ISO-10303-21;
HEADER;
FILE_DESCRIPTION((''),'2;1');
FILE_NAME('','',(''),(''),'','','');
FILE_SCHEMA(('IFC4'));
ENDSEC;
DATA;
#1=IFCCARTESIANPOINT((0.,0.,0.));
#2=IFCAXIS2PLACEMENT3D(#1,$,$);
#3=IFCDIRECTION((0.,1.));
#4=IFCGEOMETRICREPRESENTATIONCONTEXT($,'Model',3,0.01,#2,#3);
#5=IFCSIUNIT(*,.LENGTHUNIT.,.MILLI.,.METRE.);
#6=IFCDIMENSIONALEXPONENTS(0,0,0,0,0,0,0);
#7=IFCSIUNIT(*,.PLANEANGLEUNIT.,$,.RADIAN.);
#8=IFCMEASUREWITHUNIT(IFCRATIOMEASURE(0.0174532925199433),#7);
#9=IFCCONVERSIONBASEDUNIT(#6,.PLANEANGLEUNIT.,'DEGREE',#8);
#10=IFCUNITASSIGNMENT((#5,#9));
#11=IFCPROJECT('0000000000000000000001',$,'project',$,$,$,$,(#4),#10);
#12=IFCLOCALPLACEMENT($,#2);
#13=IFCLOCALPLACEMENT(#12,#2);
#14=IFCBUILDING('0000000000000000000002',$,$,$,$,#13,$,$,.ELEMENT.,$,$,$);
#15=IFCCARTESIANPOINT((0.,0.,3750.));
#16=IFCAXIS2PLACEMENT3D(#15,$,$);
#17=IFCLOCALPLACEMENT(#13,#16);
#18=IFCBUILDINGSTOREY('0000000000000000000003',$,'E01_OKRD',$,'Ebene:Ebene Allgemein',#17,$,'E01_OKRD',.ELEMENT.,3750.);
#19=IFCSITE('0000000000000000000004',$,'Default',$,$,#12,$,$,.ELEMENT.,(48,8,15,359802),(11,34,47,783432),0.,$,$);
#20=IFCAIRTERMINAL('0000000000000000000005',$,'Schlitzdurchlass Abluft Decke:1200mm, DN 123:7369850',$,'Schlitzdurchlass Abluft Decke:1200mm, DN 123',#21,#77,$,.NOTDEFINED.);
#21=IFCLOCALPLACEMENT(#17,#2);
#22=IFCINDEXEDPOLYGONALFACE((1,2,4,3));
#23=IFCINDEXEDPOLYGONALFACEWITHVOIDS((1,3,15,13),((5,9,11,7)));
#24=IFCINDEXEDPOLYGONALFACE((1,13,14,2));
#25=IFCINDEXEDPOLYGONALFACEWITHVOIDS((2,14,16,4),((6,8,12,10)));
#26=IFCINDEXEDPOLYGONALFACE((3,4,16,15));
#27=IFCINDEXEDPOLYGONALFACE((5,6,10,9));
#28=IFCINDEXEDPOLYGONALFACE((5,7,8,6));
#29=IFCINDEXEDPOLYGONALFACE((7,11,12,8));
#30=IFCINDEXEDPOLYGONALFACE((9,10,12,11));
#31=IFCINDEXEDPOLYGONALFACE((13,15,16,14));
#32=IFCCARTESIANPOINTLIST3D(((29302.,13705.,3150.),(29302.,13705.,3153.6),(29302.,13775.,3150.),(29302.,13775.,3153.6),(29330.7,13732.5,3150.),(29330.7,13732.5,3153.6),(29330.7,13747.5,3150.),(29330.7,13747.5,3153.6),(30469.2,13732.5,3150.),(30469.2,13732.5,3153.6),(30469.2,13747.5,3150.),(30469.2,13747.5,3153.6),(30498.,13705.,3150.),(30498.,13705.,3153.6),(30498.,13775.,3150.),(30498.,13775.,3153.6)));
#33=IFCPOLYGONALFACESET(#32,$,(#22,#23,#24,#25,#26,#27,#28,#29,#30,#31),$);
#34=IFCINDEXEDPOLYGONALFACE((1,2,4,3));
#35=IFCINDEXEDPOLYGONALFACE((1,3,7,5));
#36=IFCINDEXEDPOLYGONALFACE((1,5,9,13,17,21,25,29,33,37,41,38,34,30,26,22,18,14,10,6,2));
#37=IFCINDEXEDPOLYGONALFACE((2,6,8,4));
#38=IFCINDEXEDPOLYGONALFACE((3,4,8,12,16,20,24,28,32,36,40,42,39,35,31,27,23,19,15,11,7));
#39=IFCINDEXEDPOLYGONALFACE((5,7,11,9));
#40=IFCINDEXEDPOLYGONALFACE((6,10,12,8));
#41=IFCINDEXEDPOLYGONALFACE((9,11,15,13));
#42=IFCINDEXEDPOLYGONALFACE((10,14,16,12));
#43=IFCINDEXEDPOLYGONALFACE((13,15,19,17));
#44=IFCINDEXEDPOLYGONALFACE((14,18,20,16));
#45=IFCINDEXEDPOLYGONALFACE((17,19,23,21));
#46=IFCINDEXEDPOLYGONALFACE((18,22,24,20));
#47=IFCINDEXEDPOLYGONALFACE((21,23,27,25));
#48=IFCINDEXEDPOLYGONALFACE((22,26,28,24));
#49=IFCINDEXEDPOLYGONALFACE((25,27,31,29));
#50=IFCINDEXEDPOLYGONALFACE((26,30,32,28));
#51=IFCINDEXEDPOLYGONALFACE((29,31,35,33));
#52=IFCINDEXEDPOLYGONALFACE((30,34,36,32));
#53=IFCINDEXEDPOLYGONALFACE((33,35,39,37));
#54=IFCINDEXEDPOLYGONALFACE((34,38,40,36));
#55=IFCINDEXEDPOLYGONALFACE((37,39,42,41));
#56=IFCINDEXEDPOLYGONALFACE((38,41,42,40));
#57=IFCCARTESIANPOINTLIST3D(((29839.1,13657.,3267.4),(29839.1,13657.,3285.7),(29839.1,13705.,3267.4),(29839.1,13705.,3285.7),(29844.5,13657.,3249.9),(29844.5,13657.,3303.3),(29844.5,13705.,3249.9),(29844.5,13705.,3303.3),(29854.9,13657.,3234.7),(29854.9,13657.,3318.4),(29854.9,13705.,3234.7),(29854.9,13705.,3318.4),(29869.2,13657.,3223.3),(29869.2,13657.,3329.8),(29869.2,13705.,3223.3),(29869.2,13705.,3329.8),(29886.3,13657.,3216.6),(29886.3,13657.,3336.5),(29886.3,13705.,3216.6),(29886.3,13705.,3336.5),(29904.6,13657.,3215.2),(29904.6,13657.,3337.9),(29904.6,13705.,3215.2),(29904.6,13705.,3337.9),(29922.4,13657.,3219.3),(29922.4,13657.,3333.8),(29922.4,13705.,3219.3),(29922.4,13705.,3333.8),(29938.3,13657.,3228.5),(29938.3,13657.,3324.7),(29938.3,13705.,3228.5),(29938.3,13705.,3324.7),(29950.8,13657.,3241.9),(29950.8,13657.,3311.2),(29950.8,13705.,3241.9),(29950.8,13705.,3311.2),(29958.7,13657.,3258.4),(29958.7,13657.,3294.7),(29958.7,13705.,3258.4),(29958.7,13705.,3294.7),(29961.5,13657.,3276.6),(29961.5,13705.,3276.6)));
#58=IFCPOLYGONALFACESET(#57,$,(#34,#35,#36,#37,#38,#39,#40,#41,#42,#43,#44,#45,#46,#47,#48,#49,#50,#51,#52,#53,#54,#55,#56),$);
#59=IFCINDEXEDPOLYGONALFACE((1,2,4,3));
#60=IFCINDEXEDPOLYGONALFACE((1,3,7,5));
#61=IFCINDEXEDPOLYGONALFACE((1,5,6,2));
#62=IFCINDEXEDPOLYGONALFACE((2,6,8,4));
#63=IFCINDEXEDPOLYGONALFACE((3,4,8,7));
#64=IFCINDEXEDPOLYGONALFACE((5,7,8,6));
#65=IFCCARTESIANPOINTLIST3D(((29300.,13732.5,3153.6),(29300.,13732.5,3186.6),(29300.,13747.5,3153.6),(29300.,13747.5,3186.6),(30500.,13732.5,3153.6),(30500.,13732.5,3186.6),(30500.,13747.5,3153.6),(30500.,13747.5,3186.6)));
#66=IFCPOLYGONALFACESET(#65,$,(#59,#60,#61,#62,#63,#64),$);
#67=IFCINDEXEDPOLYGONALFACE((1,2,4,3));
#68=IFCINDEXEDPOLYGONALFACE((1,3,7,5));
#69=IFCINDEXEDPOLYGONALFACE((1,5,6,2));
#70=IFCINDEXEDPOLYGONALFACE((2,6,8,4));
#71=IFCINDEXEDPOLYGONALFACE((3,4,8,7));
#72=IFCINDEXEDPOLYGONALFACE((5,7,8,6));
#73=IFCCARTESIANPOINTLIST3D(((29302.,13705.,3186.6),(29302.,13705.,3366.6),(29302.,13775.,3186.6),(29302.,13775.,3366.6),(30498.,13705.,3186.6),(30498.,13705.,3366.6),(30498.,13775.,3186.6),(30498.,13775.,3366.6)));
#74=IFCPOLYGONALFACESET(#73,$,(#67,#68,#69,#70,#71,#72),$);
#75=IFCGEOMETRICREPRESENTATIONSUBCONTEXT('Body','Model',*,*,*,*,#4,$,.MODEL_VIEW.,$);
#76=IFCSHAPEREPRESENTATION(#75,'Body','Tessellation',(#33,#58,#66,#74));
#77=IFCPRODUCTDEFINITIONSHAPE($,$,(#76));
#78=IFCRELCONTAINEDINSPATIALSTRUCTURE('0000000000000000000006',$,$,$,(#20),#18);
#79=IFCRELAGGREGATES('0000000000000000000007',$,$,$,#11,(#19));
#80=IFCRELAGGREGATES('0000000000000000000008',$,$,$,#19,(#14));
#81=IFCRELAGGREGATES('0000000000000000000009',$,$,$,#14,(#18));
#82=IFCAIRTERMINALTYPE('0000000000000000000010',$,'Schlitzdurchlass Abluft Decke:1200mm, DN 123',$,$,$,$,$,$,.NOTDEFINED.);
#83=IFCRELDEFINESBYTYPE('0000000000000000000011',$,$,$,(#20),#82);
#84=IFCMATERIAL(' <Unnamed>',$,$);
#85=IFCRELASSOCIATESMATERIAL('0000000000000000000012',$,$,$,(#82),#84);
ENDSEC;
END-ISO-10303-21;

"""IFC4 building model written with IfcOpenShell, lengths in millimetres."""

from ifc_helpers import new_model, entity, si_unit, converted_unit, direction, frame, frame_2d, origin, origin_2d_with_axis, place, context, subcontext, project, spatial, polyline, rectangle, circle, outline, extrude, source, transform, mapped, material, type_object, type_shapes, element, save


model = new_model("IFC4")

# Units and contexts
model_context = context("Model", 3, precision=0.01, world=origin(), true_north=direction((0.0, 1.0)))
body_context = subcontext(model_context, "Body", "Model", "MODEL_VIEW")
ifc_project = project(units=[si_unit("LENGTHUNIT", "METRE", prefix="MILLI"), converted_unit("PLANEANGLEUNIT", "DEGREE", entity("IfcRatioMeasure", 0.0174532925199433), si_unit("PLANEANGLEUNIT", "RADIAN"), dimensions=[0, 0, 0, 0, 0, 0, 0])], contexts=[model_context])

# Site, building, storey
site_placement = place(None, origin())
site = spatial("IfcSite", under=ifc_project, at=site_placement, Name="Default", CompositionType="ELEMENT", RefLatitude=(48, 8, 15, 359802), RefLongitude=(11, 34, 47, 783432), RefElevation=0.0)
building_placement = place(site_placement, origin())
building = spatial("IfcBuilding", under=site, at=building_placement, CompositionType="ELEMENT")
storey_placement = place(building_placement, frame((0.0, 0.0, 3750.0)))
storey = spatial("IfcBuildingStorey", under=building, at=storey_placement, Name="E01_OKRD", ObjectType="Ebene:Ebene Allgemein", LongName="E01_OKRD", CompositionType="ELEMENT", Elevation=3750.0)

# Shared definitions
ifc_material_1 = material(Name=" <Unnamed>")

# Air terminal
air_terminal_type_1 = type_object("IfcAirTerminalType", Name="Schlitzdurchlass Abluft Decke:1200mm, DN 123", PredefinedType="NOTDEFINED", material=ifc_material_1)
shared_shape_1 = source(origin(), body_context, "Body", "SweptSolid", [
    extrude(outline(polyline([(-598.0, -35.0), (598.0, -35.0), (598.0, 35.0), (-598.0, 35.0), (-598.0, -35.0)]), holes=[polyline([(-569.2, -7.5), (-569.2, 7.5), (569.2, 7.5), (569.2, -7.5), (-569.2, -7.5)])]), frame((0.0, 0.0, 0.0), z_axis=(0.0, 0.0, 1.0), x_axis=(-1.0, 0.0, 0.0)), (0.0, 0.0, 1.0), 3.6),
    extrude(circle(Radius=61.5, at=frame_2d((0.0, 0.0), x_axis=(1.0, 0.0))), frame((0.0, 35.0, 126.6), z_axis=(0.0, 1.0, 0.0), x_axis=(-1.0, 0.0, 0.0)), (0.0, 0.0, 1.0), 48.0),
    extrude(rectangle(XDim=1200.0, YDim=15.0, at=origin_2d_with_axis()), frame((0.0, 0.0, 3.6), z_axis=(0.0, 0.0, 1.0), x_axis=(-1.0, 0.0, 0.0)), (0.0, 0.0, 1.0), 33.0),
    extrude(rectangle(XDim=1196.0, YDim=70.0, at=origin_2d_with_axis()), frame((0.0, 0.0, 36.6), z_axis=(0.0, 0.0, 1.0), x_axis=(-1.0, 0.0, 0.0)), (0.0, 0.0, 1.0), 180.0),
])
type_shapes(air_terminal_type_1, [shared_shape_1])
for number, where, z_axis, x_axis, name in (
    (1, (29900.0, 13740.0, 3150.0), (0.0, 0.0, 1.0), (-1.0, 0.0, 0.0), "Schlitzdurchlass Abluft Decke:1200mm, DN 123:7369850"),
):
    element("IfcAirTerminal", number, at=place(storey_placement, frame(where, z_axis=z_axis, x_axis=x_axis)), inside=storey, type_object=air_terminal_type_1, Name=name, ObjectType="Schlitzdurchlass Abluft Decke:1200mm, DN 123", PredefinedType="NOTDEFINED", context=body_context, shape_type="MappedRepresentation", body=[
        mapped(shared_shape_1, transform((0.0, 0.0, 0.0), scale=1.0)),
    ])

save(model, "model.ifc")
